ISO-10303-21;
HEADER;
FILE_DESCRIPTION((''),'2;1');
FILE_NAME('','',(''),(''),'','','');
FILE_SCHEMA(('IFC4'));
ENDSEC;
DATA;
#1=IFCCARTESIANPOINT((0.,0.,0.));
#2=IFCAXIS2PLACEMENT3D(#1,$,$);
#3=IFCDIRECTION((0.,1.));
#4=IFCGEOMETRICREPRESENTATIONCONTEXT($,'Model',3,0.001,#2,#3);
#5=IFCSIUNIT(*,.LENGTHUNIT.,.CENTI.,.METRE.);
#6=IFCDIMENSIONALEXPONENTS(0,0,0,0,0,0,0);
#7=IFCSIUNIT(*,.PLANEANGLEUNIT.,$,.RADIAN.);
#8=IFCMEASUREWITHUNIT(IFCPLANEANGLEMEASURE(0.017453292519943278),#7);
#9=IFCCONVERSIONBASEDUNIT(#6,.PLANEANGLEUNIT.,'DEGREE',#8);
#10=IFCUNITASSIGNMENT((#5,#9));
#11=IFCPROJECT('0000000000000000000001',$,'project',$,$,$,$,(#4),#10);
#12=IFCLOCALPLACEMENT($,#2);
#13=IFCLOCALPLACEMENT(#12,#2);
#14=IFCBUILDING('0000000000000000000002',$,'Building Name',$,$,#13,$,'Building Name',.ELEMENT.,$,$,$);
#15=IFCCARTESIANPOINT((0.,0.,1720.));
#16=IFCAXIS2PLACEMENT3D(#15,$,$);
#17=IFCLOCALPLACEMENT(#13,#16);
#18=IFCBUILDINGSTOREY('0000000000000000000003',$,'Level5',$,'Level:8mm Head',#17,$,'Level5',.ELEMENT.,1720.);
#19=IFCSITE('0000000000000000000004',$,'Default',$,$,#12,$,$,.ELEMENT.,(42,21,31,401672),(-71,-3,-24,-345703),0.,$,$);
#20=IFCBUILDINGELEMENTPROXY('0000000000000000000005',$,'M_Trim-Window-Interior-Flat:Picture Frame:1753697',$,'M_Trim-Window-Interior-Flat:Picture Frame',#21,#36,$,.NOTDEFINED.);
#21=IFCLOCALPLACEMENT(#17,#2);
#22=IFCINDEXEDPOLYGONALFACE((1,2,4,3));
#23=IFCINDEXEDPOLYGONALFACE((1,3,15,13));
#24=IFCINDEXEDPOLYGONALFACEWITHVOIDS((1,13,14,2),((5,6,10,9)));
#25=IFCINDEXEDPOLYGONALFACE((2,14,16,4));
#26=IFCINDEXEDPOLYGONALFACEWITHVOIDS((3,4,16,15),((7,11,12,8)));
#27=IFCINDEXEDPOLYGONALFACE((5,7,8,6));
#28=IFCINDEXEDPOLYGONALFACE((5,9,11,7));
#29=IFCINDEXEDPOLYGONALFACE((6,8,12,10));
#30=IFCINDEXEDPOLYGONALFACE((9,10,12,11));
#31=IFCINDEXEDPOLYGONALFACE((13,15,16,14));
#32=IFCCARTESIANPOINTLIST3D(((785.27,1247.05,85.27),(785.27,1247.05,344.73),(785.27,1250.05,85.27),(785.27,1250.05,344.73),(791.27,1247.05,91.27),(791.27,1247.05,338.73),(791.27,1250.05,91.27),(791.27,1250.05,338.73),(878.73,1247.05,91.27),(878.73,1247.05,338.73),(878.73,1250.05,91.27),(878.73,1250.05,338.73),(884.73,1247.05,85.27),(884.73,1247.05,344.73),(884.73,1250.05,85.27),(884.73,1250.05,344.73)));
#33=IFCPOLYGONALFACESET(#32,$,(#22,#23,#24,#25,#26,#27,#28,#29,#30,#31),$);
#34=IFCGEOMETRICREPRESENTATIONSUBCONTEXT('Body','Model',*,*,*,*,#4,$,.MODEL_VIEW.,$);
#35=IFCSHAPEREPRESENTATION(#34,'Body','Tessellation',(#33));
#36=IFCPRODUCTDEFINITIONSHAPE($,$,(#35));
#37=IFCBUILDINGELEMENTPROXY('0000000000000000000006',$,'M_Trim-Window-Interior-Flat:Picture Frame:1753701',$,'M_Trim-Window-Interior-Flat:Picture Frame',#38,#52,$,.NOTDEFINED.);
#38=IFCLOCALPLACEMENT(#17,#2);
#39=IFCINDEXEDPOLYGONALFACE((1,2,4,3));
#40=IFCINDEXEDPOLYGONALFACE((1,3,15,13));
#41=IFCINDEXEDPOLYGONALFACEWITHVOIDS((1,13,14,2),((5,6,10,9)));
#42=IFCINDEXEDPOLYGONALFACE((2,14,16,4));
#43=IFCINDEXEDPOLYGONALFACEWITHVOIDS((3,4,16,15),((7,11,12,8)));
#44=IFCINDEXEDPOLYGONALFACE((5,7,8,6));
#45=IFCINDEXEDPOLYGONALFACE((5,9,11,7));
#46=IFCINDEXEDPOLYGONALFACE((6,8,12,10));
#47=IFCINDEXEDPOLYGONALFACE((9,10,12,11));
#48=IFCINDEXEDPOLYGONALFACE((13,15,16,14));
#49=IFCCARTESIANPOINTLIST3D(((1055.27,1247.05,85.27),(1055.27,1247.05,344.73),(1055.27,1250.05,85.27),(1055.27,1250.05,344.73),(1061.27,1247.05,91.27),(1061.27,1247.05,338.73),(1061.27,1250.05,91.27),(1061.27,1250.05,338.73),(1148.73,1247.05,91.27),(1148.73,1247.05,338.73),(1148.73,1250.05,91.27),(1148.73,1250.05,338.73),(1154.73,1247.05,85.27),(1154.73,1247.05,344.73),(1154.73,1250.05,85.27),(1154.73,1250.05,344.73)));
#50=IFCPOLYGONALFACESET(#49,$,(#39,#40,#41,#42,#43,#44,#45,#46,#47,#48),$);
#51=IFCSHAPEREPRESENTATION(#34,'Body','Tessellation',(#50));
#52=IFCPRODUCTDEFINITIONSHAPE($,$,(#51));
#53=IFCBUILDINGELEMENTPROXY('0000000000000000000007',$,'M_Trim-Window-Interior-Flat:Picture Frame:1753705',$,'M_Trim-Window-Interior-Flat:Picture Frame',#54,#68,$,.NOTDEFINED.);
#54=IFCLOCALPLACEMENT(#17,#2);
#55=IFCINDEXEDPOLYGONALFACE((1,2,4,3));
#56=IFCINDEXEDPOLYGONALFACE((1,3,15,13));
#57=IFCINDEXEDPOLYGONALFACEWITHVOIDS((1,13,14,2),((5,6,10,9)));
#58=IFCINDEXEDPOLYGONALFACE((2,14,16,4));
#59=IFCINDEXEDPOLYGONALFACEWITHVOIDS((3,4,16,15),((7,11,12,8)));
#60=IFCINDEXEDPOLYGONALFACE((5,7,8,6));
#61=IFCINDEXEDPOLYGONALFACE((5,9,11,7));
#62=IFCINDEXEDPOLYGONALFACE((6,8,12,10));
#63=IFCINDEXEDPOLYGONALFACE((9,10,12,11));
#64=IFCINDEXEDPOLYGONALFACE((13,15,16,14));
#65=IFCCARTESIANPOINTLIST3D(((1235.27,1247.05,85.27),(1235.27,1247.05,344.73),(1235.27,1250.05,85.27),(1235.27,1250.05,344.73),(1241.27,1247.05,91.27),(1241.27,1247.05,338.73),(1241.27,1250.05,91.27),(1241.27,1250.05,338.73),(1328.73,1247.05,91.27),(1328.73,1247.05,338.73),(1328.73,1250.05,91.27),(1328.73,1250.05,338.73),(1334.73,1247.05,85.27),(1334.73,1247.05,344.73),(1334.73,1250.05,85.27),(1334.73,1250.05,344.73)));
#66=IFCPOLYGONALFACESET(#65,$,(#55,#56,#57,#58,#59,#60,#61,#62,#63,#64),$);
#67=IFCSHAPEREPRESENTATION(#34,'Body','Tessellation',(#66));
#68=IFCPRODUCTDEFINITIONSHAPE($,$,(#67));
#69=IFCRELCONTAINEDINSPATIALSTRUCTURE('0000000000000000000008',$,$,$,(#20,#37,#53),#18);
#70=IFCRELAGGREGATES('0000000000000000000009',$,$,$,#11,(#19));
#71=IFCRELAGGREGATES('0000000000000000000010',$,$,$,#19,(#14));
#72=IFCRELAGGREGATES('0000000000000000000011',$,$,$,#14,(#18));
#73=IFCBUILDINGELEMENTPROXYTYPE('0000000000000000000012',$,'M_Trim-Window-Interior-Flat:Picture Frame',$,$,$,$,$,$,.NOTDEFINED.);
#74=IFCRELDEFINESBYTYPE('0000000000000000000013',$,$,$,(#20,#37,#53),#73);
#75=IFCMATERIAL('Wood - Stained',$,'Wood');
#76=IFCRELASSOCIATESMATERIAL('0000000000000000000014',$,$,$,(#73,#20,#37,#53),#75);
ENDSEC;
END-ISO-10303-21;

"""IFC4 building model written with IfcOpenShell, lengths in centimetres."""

from ifc_helpers import new_model, entity, si_unit, converted_unit, direction, frame, origin, place, context, subcontext, project, spatial, indexed_curve, outline, extrude, source, transform, mapped, material, type_object, type_shapes, element, save


model = new_model("IFC4")

# Units and contexts
model_context = context("Model", 3, precision=0.001, world=origin(), true_north=direction((0.0, 1.0)))
body_context = subcontext(model_context, "Body", "Model", "MODEL_VIEW")
ifc_project = project(units=[si_unit("LENGTHUNIT", "METRE", prefix="CENTI"), converted_unit("PLANEANGLEUNIT", "DEGREE", entity("IfcPlaneAngleMeasure", 0.017453292519943278), si_unit("PLANEANGLEUNIT", "RADIAN"), dimensions=[0, 0, 0, 0, 0, 0, 0])], contexts=[model_context])

# Site, building, storey
site_placement = place(None, origin())
site = spatial("IfcSite", under=ifc_project, at=site_placement, Name="Default", CompositionType="ELEMENT", RefLatitude=(42, 21, 31, 401672), RefLongitude=(-71, -3, -24, -345703), RefElevation=0.0)
building_placement = place(site_placement, origin())
building = spatial("IfcBuilding", under=site, at=building_placement, Name="Building Name", LongName="Building Name", CompositionType="ELEMENT")
storey_placement = place(building_placement, frame((0.0, 0.0, 1720.0)))
storey = spatial("IfcBuildingStorey", under=building, at=storey_placement, Name="Level5", ObjectType="Level:8mm Head", LongName="Level5", CompositionType="ELEMENT", Elevation=1720.0)

# Building element proxies
ifc_material_1 = material(Name="Wood - Stained", Category="Wood")
building_element_proxy_type_1 = type_object("IfcBuildingElementProxyType", Name="M_Trim-Window-Interior-Flat:Picture Frame", PredefinedType="NOTDEFINED", material=ifc_material_1)
shared_shape_1 = source(origin(), body_context, "Body", "SweptSolid", [
    extrude(outline(indexed_curve([(-49.73, -129.73), (49.73, -129.73), (49.73, 129.73), (-49.73, 129.73), (-49.73, -129.73)], self_intersect=False), holes=[indexed_curve([(-43.73, -123.73), (-43.73, 123.73), (43.73, 123.73), (43.73, -123.73), (-43.73, -123.73)], self_intersect=False)]), frame((0.0, -125.0, 0.0), z_axis=(0.0, 0.0, 1.0), x_axis=(-1.0, 0.0, 0.0)), (0.0, 0.0, 1.0), 3.0),
])
type_shapes(building_element_proxy_type_1, [shared_shape_1])
for number, where, z_axis, x_axis, name in (
    (1, (835.0, 1250.05, 340.0), (0.0, -1.0, 0.0), (1.0, 0.0, 0.0), "M_Trim-Window-Interior-Flat:Picture Frame:1753697"),
    (2, (1105.0, 1250.05, 340.0), (0.0, -1.0, 0.0), (1.0, 0.0, 0.0), "M_Trim-Window-Interior-Flat:Picture Frame:1753701"),
    (3, (1285.0, 1250.05, 340.0), (0.0, -1.0, 0.0), (1.0, 0.0, 0.0), "M_Trim-Window-Interior-Flat:Picture Frame:1753705"),
):
    element("IfcBuildingElementProxy", number, at=place(storey_placement, frame(where, z_axis=z_axis, x_axis=x_axis)), inside=storey, type_object=building_element_proxy_type_1, material=ifc_material_1, Name=name, ObjectType="M_Trim-Window-Interior-Flat:Picture Frame", PredefinedType="NOTDEFINED", context=body_context, shape_type="MappedRepresentation", body=[
        mapped(shared_shape_1, transform((0.0, 0.0, 0.0), scale=1.0)),
    ])

save(model, "model.ifc")
